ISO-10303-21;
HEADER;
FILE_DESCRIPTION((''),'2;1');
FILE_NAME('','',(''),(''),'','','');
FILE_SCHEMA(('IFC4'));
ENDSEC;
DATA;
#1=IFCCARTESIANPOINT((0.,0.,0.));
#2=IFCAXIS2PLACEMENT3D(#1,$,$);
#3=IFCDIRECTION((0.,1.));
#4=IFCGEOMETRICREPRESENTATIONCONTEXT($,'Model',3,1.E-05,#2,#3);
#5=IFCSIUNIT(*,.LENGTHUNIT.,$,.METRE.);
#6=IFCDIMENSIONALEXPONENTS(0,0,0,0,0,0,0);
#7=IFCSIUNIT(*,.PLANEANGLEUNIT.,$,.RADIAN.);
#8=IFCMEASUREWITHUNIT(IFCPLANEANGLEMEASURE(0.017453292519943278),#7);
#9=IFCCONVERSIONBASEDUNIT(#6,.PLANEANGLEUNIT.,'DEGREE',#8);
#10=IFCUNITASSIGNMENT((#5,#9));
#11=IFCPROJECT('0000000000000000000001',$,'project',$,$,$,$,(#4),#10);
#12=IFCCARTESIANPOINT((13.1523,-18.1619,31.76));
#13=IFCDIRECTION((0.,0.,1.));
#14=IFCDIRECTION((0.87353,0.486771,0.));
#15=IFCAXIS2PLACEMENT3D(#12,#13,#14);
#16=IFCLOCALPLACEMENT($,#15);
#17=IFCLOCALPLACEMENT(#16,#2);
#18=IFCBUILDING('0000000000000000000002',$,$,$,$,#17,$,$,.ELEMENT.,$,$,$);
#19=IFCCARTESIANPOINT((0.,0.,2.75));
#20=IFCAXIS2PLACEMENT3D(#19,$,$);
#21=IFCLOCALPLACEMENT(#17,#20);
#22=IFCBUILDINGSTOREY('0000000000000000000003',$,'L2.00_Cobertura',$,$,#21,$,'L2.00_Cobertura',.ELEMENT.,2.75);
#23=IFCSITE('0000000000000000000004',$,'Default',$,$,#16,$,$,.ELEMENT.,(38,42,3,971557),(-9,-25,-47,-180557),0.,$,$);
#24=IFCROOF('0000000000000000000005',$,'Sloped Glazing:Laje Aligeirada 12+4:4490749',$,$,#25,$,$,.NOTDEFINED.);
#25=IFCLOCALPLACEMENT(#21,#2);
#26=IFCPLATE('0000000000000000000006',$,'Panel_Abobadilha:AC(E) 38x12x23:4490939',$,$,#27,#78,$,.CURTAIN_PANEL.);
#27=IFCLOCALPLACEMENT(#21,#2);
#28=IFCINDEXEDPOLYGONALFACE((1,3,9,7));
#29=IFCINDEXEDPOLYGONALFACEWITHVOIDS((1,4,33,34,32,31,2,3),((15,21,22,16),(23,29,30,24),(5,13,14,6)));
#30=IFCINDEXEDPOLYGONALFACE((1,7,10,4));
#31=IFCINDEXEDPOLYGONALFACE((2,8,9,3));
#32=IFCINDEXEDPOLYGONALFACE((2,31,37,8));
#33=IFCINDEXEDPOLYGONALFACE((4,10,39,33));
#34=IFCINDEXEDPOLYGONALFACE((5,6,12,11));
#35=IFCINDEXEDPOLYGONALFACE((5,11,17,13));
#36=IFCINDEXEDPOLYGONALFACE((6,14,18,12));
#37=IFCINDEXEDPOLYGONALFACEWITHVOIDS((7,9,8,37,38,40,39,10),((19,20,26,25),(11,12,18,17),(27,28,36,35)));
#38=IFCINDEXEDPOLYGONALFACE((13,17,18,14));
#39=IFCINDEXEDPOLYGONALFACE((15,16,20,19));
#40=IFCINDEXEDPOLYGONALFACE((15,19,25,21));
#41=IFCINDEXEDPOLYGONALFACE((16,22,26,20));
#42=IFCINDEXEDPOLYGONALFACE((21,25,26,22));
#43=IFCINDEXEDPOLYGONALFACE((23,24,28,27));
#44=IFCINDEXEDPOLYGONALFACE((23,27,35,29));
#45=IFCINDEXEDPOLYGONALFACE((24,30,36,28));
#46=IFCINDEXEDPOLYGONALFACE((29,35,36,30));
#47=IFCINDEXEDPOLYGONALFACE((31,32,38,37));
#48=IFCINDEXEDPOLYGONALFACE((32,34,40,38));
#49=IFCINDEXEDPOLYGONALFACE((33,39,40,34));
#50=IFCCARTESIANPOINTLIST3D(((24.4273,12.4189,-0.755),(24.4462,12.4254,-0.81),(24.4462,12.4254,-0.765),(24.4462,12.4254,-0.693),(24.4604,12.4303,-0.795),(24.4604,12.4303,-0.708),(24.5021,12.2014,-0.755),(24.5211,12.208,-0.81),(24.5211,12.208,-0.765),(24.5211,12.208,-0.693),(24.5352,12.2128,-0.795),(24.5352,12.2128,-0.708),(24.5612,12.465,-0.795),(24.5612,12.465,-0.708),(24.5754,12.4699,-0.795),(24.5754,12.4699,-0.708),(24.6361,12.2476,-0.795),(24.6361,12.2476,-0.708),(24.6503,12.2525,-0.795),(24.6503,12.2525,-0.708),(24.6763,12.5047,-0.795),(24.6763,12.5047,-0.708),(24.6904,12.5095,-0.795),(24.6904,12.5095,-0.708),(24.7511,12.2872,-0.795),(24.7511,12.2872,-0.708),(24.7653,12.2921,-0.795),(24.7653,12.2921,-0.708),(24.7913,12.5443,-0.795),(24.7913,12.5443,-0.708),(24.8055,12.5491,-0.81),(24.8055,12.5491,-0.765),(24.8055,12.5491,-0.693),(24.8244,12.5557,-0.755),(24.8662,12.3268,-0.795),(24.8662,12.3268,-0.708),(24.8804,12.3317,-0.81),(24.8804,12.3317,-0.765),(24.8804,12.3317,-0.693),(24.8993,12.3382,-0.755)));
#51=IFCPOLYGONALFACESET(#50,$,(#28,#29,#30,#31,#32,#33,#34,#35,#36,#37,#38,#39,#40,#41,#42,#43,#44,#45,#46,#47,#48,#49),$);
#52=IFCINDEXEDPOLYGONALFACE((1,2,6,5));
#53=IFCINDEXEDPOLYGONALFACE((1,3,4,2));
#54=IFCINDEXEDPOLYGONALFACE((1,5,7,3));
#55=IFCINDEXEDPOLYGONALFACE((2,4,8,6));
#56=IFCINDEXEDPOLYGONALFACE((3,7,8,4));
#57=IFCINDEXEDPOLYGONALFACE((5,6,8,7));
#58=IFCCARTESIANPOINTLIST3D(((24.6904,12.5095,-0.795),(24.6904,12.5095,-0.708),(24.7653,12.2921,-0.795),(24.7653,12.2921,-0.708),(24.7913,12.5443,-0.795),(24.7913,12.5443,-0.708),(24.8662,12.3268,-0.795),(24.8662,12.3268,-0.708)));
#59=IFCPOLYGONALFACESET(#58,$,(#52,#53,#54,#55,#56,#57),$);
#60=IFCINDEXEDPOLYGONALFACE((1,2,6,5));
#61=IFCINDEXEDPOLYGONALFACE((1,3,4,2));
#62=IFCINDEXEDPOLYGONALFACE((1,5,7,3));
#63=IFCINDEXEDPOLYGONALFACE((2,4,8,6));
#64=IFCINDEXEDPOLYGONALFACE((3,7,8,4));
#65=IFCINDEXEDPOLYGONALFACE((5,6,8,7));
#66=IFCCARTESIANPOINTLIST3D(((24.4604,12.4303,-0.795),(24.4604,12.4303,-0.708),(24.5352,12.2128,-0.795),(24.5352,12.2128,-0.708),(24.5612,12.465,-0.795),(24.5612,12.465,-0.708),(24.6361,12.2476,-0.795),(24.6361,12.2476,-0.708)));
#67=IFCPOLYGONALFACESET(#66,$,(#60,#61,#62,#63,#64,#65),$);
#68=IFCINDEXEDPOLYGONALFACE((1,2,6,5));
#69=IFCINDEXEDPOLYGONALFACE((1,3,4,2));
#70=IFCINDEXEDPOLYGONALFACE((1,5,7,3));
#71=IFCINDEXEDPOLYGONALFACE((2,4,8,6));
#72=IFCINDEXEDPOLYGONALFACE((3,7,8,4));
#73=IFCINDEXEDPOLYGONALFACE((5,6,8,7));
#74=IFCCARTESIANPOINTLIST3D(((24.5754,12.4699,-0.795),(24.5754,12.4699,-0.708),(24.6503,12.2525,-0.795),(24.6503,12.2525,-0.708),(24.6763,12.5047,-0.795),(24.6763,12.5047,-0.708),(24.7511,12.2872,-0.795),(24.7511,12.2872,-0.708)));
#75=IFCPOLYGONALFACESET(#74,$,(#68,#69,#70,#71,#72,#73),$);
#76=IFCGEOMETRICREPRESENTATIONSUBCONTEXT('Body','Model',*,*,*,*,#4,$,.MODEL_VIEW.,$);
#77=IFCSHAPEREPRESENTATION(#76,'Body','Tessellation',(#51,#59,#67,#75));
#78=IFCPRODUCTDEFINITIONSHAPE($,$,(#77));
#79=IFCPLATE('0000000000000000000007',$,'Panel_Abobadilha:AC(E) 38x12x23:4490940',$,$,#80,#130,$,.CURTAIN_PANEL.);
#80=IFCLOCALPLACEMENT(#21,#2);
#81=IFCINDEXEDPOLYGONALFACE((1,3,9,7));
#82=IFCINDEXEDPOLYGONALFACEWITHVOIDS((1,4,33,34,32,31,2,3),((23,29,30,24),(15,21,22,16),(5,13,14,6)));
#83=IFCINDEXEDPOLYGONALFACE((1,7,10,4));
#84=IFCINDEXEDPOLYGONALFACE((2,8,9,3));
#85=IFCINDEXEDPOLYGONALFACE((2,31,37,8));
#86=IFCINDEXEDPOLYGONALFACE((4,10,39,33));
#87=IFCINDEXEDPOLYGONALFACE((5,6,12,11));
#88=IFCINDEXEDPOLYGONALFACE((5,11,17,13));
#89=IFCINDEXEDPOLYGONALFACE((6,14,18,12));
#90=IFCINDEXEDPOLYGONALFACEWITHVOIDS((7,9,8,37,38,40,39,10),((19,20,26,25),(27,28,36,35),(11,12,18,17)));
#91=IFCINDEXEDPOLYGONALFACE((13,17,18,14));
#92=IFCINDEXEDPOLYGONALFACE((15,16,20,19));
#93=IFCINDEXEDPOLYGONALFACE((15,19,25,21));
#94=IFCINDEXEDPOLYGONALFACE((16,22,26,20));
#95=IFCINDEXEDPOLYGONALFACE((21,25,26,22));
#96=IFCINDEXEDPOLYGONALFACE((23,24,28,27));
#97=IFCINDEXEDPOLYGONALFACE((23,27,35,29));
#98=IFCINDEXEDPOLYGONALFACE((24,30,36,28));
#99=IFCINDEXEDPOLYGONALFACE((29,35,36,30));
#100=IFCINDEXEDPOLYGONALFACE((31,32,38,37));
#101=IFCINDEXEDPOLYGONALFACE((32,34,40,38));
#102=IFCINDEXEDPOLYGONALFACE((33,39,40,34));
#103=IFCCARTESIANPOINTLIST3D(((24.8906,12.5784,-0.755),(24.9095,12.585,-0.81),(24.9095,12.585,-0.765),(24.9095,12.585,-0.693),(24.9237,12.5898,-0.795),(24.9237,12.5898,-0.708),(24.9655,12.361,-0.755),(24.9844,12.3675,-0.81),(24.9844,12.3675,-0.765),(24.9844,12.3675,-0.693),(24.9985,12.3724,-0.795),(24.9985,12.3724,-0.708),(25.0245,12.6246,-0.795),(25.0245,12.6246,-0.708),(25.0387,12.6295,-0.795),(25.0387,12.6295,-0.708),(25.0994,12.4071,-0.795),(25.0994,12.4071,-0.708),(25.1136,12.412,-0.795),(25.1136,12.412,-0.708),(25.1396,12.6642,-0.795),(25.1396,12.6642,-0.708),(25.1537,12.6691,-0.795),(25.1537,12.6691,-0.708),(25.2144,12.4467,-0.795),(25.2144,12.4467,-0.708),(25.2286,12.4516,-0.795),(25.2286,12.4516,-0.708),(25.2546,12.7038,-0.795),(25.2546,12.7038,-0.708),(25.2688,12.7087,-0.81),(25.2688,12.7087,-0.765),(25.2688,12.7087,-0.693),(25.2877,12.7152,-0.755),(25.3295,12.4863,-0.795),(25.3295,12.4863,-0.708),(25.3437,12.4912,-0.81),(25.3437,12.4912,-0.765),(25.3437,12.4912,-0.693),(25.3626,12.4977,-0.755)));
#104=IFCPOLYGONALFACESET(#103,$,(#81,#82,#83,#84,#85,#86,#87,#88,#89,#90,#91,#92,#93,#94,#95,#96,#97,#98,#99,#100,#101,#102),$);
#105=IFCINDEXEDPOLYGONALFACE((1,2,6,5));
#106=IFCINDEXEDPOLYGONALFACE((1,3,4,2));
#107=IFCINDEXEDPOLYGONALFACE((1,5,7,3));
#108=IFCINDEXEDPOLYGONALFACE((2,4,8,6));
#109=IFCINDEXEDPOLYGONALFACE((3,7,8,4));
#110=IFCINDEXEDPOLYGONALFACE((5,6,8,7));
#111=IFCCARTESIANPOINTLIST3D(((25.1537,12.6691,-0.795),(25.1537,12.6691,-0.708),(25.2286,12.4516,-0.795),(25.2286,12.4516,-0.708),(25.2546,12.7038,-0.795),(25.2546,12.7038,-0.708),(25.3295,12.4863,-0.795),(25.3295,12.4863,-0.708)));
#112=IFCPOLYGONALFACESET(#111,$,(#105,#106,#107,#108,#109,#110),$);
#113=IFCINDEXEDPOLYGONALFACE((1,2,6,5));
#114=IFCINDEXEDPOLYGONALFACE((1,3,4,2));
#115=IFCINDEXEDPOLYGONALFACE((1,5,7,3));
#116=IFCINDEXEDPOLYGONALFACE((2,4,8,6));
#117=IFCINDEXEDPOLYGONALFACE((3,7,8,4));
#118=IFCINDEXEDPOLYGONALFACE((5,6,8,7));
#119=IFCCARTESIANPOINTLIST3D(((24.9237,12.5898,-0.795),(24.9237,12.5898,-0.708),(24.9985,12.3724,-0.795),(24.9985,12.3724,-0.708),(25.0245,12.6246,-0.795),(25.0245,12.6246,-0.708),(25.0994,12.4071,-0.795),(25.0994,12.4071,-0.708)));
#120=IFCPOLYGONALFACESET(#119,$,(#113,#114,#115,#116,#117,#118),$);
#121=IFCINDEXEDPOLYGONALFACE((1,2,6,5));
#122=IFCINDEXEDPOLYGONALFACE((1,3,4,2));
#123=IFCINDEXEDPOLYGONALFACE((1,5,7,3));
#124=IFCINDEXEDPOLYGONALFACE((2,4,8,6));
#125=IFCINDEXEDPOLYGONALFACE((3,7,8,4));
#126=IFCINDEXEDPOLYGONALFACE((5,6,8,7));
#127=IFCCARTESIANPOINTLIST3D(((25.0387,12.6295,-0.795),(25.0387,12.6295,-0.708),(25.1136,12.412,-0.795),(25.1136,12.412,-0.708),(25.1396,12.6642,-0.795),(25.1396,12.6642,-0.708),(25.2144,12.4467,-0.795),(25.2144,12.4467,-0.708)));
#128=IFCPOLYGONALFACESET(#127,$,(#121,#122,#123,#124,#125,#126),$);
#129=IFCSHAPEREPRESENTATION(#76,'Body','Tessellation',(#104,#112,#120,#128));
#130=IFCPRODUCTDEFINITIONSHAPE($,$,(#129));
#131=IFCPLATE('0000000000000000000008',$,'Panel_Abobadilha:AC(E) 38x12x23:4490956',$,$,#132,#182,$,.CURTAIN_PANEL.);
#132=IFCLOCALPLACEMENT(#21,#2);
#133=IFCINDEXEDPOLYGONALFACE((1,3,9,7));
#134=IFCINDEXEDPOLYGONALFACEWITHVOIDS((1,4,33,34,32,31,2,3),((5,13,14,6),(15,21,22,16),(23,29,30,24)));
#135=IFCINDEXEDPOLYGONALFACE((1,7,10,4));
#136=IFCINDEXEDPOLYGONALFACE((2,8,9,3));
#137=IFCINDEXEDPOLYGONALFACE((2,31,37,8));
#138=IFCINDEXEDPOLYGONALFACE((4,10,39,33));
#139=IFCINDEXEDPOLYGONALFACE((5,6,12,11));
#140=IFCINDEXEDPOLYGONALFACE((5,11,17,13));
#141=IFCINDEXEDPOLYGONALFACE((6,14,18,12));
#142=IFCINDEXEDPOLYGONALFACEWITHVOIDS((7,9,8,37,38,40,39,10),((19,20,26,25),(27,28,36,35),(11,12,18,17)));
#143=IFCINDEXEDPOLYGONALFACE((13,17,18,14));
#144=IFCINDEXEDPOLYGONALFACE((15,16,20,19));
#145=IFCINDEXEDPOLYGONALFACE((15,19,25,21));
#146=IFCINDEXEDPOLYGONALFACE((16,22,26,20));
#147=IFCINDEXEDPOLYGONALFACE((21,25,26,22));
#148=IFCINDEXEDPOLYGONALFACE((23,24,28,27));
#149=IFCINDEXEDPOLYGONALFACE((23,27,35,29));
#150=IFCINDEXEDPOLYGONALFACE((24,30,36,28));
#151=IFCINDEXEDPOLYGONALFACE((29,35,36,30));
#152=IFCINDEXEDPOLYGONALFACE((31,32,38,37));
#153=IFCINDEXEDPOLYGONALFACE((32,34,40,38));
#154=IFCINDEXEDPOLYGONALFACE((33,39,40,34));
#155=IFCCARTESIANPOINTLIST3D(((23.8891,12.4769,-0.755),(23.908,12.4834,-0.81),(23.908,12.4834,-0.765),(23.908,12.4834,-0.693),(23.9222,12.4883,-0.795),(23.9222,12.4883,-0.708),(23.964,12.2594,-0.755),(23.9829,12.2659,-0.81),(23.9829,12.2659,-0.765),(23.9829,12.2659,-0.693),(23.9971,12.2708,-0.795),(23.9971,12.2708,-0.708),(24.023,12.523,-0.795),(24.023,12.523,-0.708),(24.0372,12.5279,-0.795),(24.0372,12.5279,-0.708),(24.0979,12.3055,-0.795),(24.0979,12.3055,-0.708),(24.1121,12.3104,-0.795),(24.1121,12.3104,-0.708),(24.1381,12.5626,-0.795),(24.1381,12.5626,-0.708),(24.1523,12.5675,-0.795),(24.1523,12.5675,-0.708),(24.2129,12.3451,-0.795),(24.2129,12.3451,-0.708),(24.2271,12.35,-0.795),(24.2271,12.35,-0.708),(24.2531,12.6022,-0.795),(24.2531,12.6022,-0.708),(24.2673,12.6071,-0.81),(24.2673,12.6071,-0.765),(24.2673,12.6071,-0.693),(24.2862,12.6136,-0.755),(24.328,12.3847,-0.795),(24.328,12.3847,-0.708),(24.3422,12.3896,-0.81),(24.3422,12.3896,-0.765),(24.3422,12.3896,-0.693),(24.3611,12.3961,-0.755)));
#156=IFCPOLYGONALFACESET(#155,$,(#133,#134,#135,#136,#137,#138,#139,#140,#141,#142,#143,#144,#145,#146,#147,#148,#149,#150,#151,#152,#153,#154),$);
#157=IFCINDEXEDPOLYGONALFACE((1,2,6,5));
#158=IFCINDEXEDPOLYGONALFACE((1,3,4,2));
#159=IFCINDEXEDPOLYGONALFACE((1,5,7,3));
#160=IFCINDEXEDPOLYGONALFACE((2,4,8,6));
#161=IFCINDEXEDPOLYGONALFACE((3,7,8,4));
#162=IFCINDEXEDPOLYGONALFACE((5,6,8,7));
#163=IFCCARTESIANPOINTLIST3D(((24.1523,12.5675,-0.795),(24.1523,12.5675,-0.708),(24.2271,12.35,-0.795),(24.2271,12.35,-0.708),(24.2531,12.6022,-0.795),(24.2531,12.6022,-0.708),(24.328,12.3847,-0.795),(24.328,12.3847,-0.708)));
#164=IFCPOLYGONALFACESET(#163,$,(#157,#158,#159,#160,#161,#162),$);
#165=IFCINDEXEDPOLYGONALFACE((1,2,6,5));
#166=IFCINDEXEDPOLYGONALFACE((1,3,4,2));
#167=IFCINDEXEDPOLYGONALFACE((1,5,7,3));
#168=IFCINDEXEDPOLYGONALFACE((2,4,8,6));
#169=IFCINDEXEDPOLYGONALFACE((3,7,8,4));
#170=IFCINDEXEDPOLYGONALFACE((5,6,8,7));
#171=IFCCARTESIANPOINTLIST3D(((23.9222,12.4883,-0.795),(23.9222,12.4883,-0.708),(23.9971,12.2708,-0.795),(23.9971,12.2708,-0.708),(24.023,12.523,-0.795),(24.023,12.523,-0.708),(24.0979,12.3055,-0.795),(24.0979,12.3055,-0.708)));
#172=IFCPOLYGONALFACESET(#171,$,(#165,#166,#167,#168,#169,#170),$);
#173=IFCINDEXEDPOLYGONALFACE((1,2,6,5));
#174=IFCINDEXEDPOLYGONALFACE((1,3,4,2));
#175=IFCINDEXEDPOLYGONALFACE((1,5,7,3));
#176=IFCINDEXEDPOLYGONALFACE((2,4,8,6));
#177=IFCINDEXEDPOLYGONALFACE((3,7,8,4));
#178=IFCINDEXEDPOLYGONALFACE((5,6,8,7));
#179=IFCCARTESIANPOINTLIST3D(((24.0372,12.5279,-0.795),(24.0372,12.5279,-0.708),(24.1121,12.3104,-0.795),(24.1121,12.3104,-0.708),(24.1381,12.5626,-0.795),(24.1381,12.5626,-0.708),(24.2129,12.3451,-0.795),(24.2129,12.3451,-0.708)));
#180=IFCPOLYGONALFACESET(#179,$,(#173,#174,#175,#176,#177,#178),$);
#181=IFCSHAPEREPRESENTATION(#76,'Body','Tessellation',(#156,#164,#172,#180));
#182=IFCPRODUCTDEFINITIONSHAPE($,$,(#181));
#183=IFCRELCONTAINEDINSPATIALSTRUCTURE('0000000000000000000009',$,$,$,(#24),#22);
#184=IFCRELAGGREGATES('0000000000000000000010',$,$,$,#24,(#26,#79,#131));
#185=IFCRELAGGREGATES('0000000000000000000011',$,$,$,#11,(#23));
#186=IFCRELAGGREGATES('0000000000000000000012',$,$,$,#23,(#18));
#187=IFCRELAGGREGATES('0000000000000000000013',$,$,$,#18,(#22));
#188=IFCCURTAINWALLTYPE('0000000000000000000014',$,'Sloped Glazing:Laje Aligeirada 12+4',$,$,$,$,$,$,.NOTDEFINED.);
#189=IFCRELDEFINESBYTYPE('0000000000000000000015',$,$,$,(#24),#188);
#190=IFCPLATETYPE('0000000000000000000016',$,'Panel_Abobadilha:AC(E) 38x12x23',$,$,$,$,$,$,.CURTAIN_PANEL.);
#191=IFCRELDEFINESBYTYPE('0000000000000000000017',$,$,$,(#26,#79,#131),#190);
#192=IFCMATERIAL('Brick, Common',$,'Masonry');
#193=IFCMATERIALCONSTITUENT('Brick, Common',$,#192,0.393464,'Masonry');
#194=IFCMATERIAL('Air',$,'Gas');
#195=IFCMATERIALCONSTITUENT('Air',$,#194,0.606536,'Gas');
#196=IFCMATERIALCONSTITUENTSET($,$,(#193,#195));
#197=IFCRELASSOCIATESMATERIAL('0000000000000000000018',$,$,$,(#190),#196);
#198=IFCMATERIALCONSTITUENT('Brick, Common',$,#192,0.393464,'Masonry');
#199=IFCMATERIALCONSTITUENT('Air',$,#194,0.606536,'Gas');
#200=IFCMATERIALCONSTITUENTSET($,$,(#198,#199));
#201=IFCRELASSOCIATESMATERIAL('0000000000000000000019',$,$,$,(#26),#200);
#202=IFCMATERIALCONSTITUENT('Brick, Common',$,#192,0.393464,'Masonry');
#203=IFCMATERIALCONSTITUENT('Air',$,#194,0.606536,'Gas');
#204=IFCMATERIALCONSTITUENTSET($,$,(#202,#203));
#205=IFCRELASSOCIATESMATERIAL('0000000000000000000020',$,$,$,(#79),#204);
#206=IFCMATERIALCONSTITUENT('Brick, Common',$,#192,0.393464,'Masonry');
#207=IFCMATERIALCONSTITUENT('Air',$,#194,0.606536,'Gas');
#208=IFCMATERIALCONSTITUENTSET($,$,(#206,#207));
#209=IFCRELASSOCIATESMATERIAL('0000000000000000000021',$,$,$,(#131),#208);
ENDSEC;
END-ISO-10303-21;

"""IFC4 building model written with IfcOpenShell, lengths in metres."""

from ifc_helpers import new_model, entity, si_unit, converted_unit, direction, frame, origin, place, context, subcontext, project, spatial, indexed_curve, outline, extrude, source, transform, mapped, material, constituent, constituent_set, type_object, type_shapes, element, aggregate, save


model = new_model("IFC4")

# Units and contexts
model_context = context("Model", 3, precision=1e-05, world=origin(), true_north=direction((0.0, 1.0)))
body_context = subcontext(model_context, "Body", "Model", "MODEL_VIEW")
ifc_project = project(units=[si_unit("LENGTHUNIT", "METRE"), converted_unit("PLANEANGLEUNIT", "DEGREE", entity("IfcPlaneAngleMeasure", 0.017453292519943278), si_unit("PLANEANGLEUNIT", "RADIAN"), dimensions=[0, 0, 0, 0, 0, 0, 0])], contexts=[model_context])

# Site, building, storey
site_placement = place(None, frame((13.1523, -18.1619, 31.76), z_axis=(0.0, 0.0, 1.0), x_axis=(0.87353, 0.486771, 0.0)))
site = spatial("IfcSite", under=ifc_project, at=site_placement, Name="Default", CompositionType="ELEMENT", RefLatitude=(38, 42, 3, 971557), RefLongitude=(-9, -25, -47, -180557), RefElevation=0.0)
building_placement = place(site_placement, origin())
building = spatial("IfcBuilding", under=site, at=building_placement, CompositionType="ELEMENT")
storey_placement = place(building_placement, frame((0.0, 0.0, 2.75)))
storey = spatial("IfcBuildingStorey", under=building, at=storey_placement, Name="L2.00_Cobertura", LongName="L2.00_Cobertura", CompositionType="ELEMENT", Elevation=2.75)

# Roof, plates
curtain_wall_type = type_object("IfcCurtainWallType", Name="Sloped Glazing:Laje Aligeirada 12+4", PredefinedType="NOTDEFINED")
roof_placement = place(storey_placement, frame((0.0, 0.0, -2.75)))
roof = element("IfcRoof", 1, at=roof_placement, inside=storey, type_object=curtain_wall_type, Name="Sloped Glazing:Laje Aligeirada 12+4:4490749", PredefinedType="NOTDEFINED")
ifc_material_1 = material(Name="Brick, Common", Category="Masonry")
ifc_material_2 = material(Name="Air", Category="Gas")
ifc_constituent_1 = constituent(ifc_material_1, Name="Brick, Common", Category="Masonry", fraction=0.393464)
ifc_constituent_2 = constituent(ifc_material_2, Name="Air", Category="Gas", fraction=0.606536)
ifc_constituent_set_1 = constituent_set(constituents=[ifc_constituent_1, ifc_constituent_2])
plate_type = type_object("IfcPlateType", Name="Panel_Abobadilha:AC(E) 38x12x23", PredefinedType="CURTAIN_PANEL", material=ifc_constituent_set_1)
shared_shape_1 = source(origin(), body_context, "Body", "SweptSolid", [
    extrude(outline(indexed_curve([(-0.19, -0.0543), (0.19, -0.0543), (0.19, -0.0093), (0.21, 0.0007), (0.19, 0.0628), (-0.19, 0.0628), (-0.21, 0.0007), (-0.19, -0.0093), (-0.19, -0.0543)], self_intersect=False), holes=[indexed_curve([(-0.0683, 0.0477), (-0.0683, -0.0393), (-0.175, -0.0393), (-0.175, 0.0477), (-0.0683, 0.0477)], self_intersect=False), indexed_curve([(0.0533, 0.0477), (0.0533, -0.0393), (-0.0533, -0.0393), (-0.0533, 0.0477), (0.0533, 0.0477)], self_intersect=False), indexed_curve([(0.175, 0.0477), (0.175, -0.0393), (0.0683, -0.0393), (0.0683, 0.0477), (0.175, 0.0477)], self_intersect=False)]), frame((0.0, 0.0543, 0.0)), (0.0, 0.0, 1.0), 0.23),
    extrude(outline(indexed_curve([(-0.0533, -0.0435), (0.0533, -0.0435), (0.0533, 0.0435), (-0.0533, 0.0435), (-0.0533, -0.0435)], self_intersect=False)), frame((0.1217, 0.0585, 0.0), z_axis=(0.0, 0.0, 1.0), x_axis=(-1.0, 0.0, 0.0)), (0.0, 0.0, 1.0), 0.23),
    extrude(outline(indexed_curve([(-0.0533, -0.0435), (0.0533, -0.0435), (0.0533, 0.0435), (-0.0533, 0.0435), (-0.0533, -0.0435)], self_intersect=False)), frame((-0.1217, 0.0585, 0.0), z_axis=(0.0, 0.0, 1.0), x_axis=(-1.0, 0.0, 0.0)), (0.0, 0.0, 1.0), 0.23),
    extrude(outline(indexed_curve([(-0.0533, -0.0435), (0.0533, -0.0435), (0.0533, 0.0435), (-0.0533, 0.0435), (-0.0533, -0.0435)], self_intersect=False)), frame((0.0, 0.0585, 0.0), z_axis=(0.0, 0.0, 1.0), x_axis=(-1.0, 0.0, 0.0)), (0.0, 0.0, 1.0), 0.23),
])
type_shapes(plate_type, [shared_shape_1])
ifc_constituent_3 = constituent(ifc_material_1, Name="Brick, Common", Category="Masonry", fraction=0.393464)
ifc_constituent_4 = constituent(ifc_material_2, Name="Air", Category="Gas", fraction=0.606536)
ifc_constituent_set_2 = constituent_set(constituents=[ifc_constituent_3, ifc_constituent_4])
plate_1_placement = place(roof_placement, frame((24.6258, 12.4873, 1.94), z_axis=(0.325568, -0.945519, 0.0), x_axis=(0.945519, 0.325568, 0.0)))
plate_1 = element("IfcPlate", 2, at=plate_1_placement, type_object=plate_type, material=ifc_constituent_set_2, Name="Panel_Abobadilha:AC(E) 38x12x23:4490939", PredefinedType="CURTAIN_PANEL", context=body_context, shape_type="MappedRepresentation", body=[
    mapped(shared_shape_1, transform((0.0, 0.0, 0.0), scale=1.0)),
])
ifc_constituent_5 = constituent(ifc_material_1, Name="Brick, Common", Category="Masonry", fraction=0.393464)
ifc_constituent_6 = constituent(ifc_material_2, Name="Air", Category="Gas", fraction=0.606536)
ifc_constituent_set_3 = constituent_set(constituents=[ifc_constituent_5, ifc_constituent_6])
plate_2_placement = place(roof_placement, frame((25.0891, 12.6468, 1.94), z_axis=(0.325568, -0.945519, 0.0), x_axis=(0.945519, 0.325568, 0.0)))
plate_2 = element("IfcPlate", 3, at=plate_2_placement, type_object=plate_type, material=ifc_constituent_set_3, Name="Panel_Abobadilha:AC(E) 38x12x23:4490940", PredefinedType="CURTAIN_PANEL", context=body_context, shape_type="MappedRepresentation", body=[
    mapped(shared_shape_1, transform((0.0, 0.0, 0.0), scale=1.0)),
])
ifc_constituent_7 = constituent(ifc_material_1, Name="Brick, Common", Category="Masonry", fraction=0.393464)
ifc_constituent_8 = constituent(ifc_material_2, Name="Air", Category="Gas", fraction=0.606536)
ifc_constituent_set_4 = constituent_set(constituents=[ifc_constituent_7, ifc_constituent_8])
plate_3_placement = place(roof_placement, frame((24.0876, 12.5452, 1.94), z_axis=(0.325568, -0.945519, 0.0), x_axis=(0.945519, 0.325568, 0.0)))
plate_3 = element("IfcPlate", 4, at=plate_3_placement, type_object=plate_type, material=ifc_constituent_set_4, Name="Panel_Abobadilha:AC(E) 38x12x23:4490956", PredefinedType="CURTAIN_PANEL", context=body_context, shape_type="MappedRepresentation", body=[
    mapped(shared_shape_1, transform((0.0, 0.0, 0.0), scale=1.0)),
])
aggregate(roof, [plate_1, plate_2, plate_3])

save(model, "model.ifc")
